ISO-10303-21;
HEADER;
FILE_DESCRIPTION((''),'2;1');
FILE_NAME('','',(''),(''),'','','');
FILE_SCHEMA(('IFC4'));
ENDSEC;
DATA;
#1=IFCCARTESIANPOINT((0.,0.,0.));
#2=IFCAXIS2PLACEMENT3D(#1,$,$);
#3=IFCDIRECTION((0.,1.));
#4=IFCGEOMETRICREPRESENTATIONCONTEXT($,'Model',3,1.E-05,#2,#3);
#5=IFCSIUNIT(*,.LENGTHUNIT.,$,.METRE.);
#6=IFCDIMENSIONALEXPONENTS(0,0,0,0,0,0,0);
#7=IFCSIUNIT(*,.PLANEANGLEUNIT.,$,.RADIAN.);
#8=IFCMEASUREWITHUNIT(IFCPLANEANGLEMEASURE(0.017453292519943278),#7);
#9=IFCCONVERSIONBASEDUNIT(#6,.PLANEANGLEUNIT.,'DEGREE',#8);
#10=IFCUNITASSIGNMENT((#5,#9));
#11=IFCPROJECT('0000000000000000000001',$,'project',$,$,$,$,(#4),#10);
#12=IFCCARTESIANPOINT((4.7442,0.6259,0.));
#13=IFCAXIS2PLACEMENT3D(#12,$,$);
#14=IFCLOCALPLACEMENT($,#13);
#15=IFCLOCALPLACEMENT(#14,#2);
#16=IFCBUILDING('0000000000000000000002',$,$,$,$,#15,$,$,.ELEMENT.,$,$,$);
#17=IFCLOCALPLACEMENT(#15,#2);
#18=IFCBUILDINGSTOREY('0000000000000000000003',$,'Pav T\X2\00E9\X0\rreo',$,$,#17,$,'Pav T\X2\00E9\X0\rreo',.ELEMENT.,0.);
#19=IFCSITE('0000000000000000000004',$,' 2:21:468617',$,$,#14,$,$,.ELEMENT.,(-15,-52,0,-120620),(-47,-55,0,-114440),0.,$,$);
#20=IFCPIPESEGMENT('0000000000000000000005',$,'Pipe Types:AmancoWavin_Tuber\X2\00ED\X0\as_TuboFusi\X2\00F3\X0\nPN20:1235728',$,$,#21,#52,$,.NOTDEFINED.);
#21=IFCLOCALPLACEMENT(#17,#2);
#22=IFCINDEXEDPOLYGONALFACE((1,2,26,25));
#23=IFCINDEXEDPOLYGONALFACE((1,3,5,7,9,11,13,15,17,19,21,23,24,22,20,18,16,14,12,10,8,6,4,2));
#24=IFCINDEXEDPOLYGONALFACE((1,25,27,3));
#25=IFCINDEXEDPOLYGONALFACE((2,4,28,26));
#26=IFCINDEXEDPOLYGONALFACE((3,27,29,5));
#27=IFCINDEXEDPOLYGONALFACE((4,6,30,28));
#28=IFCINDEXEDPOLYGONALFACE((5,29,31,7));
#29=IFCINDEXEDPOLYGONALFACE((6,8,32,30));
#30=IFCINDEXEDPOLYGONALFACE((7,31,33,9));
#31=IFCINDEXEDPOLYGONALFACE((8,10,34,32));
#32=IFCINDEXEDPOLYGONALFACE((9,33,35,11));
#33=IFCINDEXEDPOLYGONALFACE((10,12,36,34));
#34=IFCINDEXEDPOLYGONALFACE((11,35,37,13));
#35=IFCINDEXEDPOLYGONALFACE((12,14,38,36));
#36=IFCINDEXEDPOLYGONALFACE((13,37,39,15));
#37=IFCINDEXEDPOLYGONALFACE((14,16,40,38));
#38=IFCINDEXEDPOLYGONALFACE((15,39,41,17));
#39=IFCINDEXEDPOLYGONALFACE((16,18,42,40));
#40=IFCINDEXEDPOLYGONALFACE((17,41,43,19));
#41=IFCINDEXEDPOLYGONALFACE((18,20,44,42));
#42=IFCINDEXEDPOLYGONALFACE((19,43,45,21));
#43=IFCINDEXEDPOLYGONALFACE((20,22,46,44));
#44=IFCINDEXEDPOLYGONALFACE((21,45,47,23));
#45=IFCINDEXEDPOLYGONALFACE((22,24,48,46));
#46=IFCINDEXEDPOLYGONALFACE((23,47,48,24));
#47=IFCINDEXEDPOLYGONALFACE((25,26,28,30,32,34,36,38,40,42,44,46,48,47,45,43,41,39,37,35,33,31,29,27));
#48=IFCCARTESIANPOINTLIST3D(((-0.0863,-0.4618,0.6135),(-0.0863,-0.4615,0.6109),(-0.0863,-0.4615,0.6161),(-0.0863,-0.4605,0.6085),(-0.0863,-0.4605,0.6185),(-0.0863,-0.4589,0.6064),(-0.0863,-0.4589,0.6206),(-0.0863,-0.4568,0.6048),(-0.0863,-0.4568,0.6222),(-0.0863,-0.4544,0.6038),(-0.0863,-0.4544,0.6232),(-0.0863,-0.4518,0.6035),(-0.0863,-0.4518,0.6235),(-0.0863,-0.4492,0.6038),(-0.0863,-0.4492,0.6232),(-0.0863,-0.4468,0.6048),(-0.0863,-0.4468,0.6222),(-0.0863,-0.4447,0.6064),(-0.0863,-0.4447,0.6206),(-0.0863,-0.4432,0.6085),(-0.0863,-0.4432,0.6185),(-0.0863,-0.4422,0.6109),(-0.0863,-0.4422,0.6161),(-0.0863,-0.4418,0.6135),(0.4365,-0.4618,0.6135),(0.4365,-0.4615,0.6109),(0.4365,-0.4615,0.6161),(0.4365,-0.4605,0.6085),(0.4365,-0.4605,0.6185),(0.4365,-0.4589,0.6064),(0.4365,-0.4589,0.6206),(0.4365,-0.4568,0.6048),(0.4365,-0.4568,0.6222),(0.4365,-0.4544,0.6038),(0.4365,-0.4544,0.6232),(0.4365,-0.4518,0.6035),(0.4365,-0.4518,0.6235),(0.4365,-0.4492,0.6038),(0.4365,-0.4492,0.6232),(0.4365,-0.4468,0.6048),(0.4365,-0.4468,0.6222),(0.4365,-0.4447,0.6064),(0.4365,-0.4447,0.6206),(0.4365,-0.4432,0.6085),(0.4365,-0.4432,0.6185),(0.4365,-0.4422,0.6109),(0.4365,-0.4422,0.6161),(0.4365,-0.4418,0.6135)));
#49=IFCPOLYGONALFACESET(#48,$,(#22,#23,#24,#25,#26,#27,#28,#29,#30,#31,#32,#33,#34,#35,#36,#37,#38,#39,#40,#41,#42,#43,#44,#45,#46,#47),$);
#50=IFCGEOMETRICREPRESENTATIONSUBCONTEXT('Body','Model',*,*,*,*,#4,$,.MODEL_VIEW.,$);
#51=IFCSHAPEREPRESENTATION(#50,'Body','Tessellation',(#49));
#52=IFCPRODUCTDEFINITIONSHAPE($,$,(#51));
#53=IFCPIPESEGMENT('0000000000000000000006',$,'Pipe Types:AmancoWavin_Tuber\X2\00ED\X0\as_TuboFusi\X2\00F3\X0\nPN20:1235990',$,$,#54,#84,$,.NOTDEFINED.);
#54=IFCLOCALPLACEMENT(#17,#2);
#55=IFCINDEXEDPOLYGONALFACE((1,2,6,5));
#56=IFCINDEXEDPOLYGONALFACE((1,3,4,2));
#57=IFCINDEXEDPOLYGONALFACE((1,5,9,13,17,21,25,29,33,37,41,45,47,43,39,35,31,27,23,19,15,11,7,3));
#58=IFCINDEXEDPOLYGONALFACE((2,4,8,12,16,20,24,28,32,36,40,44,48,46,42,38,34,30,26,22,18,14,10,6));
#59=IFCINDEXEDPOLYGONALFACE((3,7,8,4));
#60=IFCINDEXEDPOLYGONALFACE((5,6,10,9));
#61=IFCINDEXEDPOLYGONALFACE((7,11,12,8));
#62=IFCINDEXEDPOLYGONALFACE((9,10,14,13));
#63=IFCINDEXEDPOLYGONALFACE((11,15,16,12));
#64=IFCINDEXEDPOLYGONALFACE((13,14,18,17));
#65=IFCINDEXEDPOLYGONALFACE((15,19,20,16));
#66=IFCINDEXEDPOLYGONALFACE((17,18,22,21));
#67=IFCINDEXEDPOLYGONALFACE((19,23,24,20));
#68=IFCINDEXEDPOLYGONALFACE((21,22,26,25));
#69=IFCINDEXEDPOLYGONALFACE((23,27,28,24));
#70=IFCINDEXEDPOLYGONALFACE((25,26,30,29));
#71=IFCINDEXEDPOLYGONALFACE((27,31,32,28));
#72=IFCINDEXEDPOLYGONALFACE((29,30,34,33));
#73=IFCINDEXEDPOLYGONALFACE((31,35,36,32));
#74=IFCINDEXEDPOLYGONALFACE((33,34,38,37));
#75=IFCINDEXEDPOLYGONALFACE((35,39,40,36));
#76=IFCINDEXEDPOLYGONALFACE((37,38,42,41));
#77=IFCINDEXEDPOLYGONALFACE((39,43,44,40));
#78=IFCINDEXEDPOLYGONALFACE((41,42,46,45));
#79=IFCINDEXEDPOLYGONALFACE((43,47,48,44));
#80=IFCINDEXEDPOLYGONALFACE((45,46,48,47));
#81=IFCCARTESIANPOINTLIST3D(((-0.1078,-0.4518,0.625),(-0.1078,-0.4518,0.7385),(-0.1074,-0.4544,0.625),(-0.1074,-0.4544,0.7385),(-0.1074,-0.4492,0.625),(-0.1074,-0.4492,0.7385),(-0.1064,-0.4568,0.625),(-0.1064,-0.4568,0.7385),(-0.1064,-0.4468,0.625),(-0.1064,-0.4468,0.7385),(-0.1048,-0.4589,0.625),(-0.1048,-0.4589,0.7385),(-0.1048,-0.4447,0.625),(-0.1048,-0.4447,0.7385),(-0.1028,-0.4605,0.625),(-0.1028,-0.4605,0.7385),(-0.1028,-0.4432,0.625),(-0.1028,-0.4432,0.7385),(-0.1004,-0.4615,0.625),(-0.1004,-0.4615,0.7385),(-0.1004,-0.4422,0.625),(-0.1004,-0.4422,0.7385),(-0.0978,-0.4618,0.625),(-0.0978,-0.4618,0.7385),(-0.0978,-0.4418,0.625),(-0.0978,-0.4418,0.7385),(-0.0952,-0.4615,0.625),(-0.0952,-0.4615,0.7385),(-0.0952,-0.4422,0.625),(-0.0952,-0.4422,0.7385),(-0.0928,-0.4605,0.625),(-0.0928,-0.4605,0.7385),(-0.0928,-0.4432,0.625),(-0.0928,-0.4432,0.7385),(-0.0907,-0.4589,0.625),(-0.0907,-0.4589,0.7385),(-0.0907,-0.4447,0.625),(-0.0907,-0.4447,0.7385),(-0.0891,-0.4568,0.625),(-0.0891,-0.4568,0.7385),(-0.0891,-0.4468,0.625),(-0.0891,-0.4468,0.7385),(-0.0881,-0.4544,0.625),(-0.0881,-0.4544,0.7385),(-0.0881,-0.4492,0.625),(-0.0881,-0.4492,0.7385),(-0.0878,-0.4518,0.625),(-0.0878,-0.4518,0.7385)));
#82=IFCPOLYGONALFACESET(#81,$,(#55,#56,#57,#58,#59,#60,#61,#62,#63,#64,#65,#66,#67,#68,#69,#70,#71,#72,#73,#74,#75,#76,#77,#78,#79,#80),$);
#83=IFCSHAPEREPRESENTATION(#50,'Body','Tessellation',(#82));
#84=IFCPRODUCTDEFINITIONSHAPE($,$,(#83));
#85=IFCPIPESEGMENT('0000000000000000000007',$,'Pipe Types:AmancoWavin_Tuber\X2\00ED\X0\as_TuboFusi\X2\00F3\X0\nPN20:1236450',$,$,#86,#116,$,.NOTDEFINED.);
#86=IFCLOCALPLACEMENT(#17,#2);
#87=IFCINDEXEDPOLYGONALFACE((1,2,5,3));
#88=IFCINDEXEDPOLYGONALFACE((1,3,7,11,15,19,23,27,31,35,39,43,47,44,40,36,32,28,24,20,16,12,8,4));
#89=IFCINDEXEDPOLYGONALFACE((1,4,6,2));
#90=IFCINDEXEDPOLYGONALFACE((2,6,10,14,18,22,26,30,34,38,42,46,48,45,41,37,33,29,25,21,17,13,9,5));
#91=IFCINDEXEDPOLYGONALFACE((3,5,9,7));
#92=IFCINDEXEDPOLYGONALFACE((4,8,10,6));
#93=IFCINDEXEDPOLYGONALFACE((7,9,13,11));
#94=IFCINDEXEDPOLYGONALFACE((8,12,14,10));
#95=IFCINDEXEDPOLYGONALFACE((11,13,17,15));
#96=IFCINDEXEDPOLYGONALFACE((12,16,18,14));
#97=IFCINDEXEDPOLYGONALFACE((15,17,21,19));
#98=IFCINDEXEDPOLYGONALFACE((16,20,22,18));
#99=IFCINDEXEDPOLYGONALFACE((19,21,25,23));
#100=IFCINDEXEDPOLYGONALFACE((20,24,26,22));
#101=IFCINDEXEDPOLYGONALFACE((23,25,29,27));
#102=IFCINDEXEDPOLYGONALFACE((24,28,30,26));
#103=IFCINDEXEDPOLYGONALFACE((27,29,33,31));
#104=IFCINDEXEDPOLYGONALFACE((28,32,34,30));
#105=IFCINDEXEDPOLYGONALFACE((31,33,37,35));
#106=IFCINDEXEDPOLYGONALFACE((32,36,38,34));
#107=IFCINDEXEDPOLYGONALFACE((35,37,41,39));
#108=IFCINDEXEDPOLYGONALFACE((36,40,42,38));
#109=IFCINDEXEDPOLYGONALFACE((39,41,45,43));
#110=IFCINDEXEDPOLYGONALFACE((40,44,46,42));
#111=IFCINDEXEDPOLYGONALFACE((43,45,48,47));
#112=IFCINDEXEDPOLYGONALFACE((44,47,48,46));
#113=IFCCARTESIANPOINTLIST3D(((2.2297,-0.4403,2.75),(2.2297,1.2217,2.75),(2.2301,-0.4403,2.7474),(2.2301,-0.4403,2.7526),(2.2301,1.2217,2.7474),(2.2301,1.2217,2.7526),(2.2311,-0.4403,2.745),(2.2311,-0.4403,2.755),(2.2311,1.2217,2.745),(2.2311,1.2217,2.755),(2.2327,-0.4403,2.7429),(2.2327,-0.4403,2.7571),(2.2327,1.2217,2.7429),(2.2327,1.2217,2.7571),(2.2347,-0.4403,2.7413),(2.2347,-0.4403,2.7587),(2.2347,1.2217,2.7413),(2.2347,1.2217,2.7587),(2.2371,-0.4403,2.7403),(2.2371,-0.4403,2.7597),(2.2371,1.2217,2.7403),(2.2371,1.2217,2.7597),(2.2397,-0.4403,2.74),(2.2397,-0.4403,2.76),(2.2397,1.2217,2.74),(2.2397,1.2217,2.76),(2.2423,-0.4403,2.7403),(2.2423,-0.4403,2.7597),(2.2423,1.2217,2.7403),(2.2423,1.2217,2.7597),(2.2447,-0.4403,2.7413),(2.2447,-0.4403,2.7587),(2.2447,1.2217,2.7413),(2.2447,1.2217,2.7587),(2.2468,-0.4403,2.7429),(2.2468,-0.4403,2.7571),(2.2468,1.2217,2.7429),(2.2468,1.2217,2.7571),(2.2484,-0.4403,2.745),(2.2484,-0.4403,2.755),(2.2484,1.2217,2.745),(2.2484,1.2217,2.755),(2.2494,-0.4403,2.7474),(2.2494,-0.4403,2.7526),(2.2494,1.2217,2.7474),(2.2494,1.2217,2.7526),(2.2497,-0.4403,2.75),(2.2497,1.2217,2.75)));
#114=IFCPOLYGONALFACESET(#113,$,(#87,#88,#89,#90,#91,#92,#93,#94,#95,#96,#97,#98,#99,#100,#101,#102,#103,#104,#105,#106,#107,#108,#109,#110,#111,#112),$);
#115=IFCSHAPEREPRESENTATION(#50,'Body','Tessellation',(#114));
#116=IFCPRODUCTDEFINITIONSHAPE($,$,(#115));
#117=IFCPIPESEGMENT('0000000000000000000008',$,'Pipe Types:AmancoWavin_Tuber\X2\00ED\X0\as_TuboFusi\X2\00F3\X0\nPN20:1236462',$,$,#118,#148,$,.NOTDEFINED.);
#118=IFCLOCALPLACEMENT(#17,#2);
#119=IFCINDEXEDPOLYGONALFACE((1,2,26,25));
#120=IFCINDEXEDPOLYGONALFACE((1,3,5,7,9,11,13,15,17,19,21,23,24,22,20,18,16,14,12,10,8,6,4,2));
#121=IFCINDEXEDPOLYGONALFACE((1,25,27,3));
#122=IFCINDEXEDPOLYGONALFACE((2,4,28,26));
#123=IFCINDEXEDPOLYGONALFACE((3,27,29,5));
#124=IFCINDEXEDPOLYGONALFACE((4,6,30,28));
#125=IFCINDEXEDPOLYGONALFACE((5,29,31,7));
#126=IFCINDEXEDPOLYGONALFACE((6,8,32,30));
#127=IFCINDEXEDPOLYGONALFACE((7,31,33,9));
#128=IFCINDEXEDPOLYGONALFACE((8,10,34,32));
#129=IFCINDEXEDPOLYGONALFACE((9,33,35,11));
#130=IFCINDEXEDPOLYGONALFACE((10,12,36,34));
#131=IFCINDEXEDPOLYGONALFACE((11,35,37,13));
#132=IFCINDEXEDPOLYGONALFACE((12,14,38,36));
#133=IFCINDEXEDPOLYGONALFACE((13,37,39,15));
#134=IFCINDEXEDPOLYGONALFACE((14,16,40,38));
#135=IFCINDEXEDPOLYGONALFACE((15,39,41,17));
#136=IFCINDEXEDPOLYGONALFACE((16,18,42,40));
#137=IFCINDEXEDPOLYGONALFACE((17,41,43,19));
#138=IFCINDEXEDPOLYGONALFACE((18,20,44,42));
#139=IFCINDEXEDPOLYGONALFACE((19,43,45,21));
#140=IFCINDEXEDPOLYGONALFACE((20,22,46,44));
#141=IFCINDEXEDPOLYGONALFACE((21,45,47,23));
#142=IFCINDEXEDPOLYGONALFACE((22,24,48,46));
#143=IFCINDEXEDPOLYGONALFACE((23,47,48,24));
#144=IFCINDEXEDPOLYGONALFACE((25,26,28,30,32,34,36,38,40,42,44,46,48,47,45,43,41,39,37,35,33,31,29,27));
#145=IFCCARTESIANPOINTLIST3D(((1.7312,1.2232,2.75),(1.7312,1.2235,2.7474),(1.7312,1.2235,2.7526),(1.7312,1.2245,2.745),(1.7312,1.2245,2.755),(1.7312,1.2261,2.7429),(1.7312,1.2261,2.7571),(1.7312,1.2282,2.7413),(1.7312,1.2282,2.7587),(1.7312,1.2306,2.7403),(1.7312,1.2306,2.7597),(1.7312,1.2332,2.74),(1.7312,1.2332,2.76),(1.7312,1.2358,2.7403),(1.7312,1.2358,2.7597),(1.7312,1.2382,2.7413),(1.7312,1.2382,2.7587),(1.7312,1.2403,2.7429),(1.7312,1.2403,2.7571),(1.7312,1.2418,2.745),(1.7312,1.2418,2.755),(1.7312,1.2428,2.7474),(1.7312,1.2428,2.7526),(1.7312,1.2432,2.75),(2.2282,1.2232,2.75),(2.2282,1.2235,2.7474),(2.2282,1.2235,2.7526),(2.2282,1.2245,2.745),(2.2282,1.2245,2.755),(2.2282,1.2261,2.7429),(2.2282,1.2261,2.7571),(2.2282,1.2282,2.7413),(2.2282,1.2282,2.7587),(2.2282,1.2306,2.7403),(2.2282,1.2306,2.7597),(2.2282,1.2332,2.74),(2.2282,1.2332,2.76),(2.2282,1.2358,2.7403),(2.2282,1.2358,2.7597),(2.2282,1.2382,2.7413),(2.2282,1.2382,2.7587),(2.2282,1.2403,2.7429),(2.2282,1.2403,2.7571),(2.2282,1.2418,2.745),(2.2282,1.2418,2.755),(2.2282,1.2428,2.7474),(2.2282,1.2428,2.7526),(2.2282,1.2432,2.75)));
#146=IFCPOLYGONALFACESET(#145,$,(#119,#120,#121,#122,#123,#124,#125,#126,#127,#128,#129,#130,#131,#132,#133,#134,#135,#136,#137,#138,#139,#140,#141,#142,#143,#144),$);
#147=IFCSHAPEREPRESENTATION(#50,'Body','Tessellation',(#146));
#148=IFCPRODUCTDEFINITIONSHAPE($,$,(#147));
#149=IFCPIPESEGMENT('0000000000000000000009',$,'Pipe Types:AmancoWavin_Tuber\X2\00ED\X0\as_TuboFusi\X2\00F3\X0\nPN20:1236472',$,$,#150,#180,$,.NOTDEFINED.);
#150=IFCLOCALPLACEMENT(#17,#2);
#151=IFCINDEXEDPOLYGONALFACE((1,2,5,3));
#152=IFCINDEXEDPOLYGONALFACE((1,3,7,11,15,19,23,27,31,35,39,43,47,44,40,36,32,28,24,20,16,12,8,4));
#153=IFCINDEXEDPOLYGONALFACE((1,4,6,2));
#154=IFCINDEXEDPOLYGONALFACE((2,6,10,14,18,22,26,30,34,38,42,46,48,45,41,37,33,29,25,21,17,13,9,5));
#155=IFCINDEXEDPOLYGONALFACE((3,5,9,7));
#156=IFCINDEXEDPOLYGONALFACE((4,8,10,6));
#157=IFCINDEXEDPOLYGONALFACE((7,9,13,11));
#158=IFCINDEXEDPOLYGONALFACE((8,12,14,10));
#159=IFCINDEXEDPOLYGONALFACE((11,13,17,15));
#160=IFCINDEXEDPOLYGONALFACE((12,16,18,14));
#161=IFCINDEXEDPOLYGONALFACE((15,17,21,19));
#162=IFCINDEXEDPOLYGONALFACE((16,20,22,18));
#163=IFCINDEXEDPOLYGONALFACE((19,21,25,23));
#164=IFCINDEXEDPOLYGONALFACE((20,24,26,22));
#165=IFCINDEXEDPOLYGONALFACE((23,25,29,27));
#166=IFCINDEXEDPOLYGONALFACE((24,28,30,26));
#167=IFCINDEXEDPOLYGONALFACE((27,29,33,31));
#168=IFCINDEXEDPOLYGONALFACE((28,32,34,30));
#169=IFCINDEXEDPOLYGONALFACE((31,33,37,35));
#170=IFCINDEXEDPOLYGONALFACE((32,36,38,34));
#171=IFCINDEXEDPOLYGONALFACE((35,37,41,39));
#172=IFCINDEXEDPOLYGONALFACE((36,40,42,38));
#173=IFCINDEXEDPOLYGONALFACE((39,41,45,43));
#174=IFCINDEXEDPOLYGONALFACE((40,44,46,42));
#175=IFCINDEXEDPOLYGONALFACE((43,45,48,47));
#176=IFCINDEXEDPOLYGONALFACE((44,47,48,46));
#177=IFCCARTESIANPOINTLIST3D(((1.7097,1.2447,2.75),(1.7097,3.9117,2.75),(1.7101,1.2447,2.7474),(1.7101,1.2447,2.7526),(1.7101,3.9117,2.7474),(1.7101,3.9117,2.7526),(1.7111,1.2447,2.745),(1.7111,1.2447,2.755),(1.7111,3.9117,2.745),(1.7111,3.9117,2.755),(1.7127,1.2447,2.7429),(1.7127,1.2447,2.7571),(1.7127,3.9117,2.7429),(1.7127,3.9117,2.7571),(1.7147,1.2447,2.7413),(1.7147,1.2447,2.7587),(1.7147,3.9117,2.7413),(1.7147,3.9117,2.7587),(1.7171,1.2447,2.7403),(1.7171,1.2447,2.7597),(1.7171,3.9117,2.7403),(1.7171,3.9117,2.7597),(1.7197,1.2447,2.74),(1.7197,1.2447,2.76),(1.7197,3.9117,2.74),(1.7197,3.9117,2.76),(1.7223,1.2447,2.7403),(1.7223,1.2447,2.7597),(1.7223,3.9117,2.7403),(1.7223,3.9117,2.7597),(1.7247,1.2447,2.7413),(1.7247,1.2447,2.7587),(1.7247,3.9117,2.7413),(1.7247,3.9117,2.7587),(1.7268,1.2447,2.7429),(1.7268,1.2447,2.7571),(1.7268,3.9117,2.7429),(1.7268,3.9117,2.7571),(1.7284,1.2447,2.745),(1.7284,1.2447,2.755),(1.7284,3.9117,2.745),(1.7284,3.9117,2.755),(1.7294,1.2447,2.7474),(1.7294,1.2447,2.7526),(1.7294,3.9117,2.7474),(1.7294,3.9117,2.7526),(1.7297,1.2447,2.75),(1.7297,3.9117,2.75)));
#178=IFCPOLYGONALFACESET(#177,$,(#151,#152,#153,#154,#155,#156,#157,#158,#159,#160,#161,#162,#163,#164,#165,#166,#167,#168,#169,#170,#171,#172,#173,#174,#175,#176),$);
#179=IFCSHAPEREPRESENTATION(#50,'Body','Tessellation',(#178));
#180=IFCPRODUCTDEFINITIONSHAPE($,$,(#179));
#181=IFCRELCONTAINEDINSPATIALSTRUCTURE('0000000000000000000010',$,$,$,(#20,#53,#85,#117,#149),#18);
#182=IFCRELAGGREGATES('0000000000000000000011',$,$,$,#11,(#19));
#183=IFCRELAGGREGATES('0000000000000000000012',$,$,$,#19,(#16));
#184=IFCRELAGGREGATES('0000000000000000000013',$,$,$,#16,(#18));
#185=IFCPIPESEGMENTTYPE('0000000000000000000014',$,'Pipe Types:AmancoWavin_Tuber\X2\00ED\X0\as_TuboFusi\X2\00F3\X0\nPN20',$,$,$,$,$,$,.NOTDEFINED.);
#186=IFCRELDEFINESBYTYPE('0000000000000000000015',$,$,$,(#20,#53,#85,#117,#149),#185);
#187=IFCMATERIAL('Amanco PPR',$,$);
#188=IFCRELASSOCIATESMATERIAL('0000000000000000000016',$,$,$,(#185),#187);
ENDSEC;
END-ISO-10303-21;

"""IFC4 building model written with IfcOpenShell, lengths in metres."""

from ifc_helpers import new_model, entity, si_unit, converted_unit, direction, frame, origin, place, context, subcontext, project, spatial, arc, indexed_curve, outline, extrude, material, type_object, element, save


model = new_model("IFC4")

# Units and contexts
model_context = context("Model", 3, precision=1e-05, world=origin(), true_north=direction((0.0, 1.0)))
body_context = subcontext(model_context, "Body", "Model", "MODEL_VIEW")
ifc_project = project(units=[si_unit("LENGTHUNIT", "METRE"), converted_unit("PLANEANGLEUNIT", "DEGREE", entity("IfcPlaneAngleMeasure", 0.017453292519943278), si_unit("PLANEANGLEUNIT", "RADIAN"), dimensions=[0, 0, 0, 0, 0, 0, 0])], contexts=[model_context])

# Site, building, storey
site_placement = place(None, frame((4.7442, 0.6259, 0.0)))
site = spatial("IfcSite", under=ifc_project, at=site_placement, Name=" 2:21:468617", CompositionType="ELEMENT", RefLatitude=(-15, -52, 0, -120620), RefLongitude=(-47, -55, 0, -114440), RefElevation=0.0)
building_placement = place(site_placement, origin())
building = spatial("IfcBuilding", under=site, at=building_placement, CompositionType="ELEMENT")
storey_placement = place(building_placement, origin())
storey = spatial("IfcBuildingStorey", under=building, at=storey_placement, Name="Pav Térreo", LongName="Pav Térreo", CompositionType="ELEMENT", Elevation=0.0)

# Pipe segments
ifc_material_1 = material(Name="Amanco PPR")
pipe_segment_type_1 = type_object("IfcPipeSegmentType", Name="Pipe Types:AmancoWavin_Tuberías_TuboFusiónPN20", PredefinedType="NOTDEFINED", material=ifc_material_1)
pipe_segment_1_placement = place(storey_placement, origin())
element("IfcPipeSegment", 1, at=pipe_segment_1_placement, inside=storey, type_object=pipe_segment_type_1, Name="Pipe Types:AmancoWavin_Tuberías_TuboFusiónPN20:1235728", PredefinedType="NOTDEFINED", context=body_context, shape_type="SweptSolid", body=[
    extrude(outline(indexed_curve([(0.01, 0.0), (0.0071, 0.0071), (0.0, 0.01), (-0.0071, 0.0071), (-0.01, 0.0), (-0.0071, -0.0071), (0.0, -0.01), (0.0071, -0.0071)], segments=[arc(1, 2, 3), arc(3, 4, 5), arc(5, 6, 7), arc(7, 8, 1)], self_intersect=False)), frame((-0.0863, -0.4518, 0.6135), z_axis=(1.0, 0.0, 0.0), x_axis=(0.0, 1.0, 0.0)), (0.0, 0.0, 1.0), 0.5228),
])
pipe_segment_2_placement = place(storey_placement, origin())
element("IfcPipeSegment", 2, at=pipe_segment_2_placement, inside=storey, type_object=pipe_segment_type_1, Name="Pipe Types:AmancoWavin_Tuberías_TuboFusiónPN20:1235990", PredefinedType="NOTDEFINED", context=body_context, shape_type="SweptSolid", body=[
    extrude(outline(indexed_curve([(0.01, 0.0), (0.0071, 0.0071), (0.0, 0.01), (-0.0071, 0.0071), (-0.01, 0.0), (-0.0071, -0.0071), (0.0, -0.01), (0.0071, -0.0071)], segments=[arc(1, 2, 3), arc(3, 4, 5), arc(5, 6, 7), arc(7, 8, 1)], self_intersect=False)), frame((-0.0978, -0.4518, 0.625), z_axis=(0.0, 0.0, 1.0), x_axis=(-1.0, 0.0, 0.0)), (0.0, 0.0, 1.0), 0.1135),
])
pipe_segment_3_placement = place(storey_placement, origin())
element("IfcPipeSegment", 3, at=pipe_segment_3_placement, inside=storey, type_object=pipe_segment_type_1, Name="Pipe Types:AmancoWavin_Tuberías_TuboFusiónPN20:1236450", PredefinedType="NOTDEFINED", context=body_context, shape_type="SweptSolid", body=[
    extrude(outline(indexed_curve([(0.01, 0.0), (0.0071, 0.0071), (0.0, 0.01), (-0.0071, 0.0071), (-0.01, 0.0), (-0.0071, -0.0071), (0.0, -0.01), (0.0071, -0.0071)], segments=[arc(1, 2, 3), arc(3, 4, 5), arc(5, 6, 7), arc(7, 8, 1)], self_intersect=False)), frame((2.2397, -0.4403, 2.75), z_axis=(0.0, 1.0, 0.0), x_axis=(1.0, 0.0, 0.0)), (0.0, 0.0, 1.0), 1.662),
])
pipe_segment_4_placement = place(storey_placement, origin())
element("IfcPipeSegment", 4, at=pipe_segment_4_placement, inside=storey, type_object=pipe_segment_type_1, Name="Pipe Types:AmancoWavin_Tuberías_TuboFusiónPN20:1236462", PredefinedType="NOTDEFINED", context=body_context, shape_type="SweptSolid", body=[
    extrude(outline(indexed_curve([(0.01, 0.0), (0.0071, 0.0071), (0.0, 0.01), (-0.0071, 0.0071), (-0.01, 0.0), (-0.0071, -0.0071), (0.0, -0.01), (0.0071, -0.0071)], segments=[arc(1, 2, 3), arc(3, 4, 5), arc(5, 6, 7), arc(7, 8, 1)], self_intersect=False)), frame((1.7312, 1.2332, 2.75), z_axis=(1.0, 0.0, 0.0), x_axis=(0.0, 1.0, 0.0)), (0.0, 0.0, 1.0), 0.497),
])
pipe_segment_5_placement = place(storey_placement, origin())
element("IfcPipeSegment", 5, at=pipe_segment_5_placement, inside=storey, type_object=pipe_segment_type_1, Name="Pipe Types:AmancoWavin_Tuberías_TuboFusiónPN20:1236472", PredefinedType="NOTDEFINED", context=body_context, shape_type="SweptSolid", body=[
    extrude(outline(indexed_curve([(0.01, 0.0), (0.0071, 0.0071), (0.0, 0.01), (-0.0071, 0.0071), (-0.01, 0.0), (-0.0071, -0.0071), (0.0, -0.01), (0.0071, -0.0071)], segments=[arc(1, 2, 3), arc(3, 4, 5), arc(5, 6, 7), arc(7, 8, 1)], self_intersect=False)), frame((1.7197, 1.2447, 2.75), z_axis=(0.0, 1.0, 0.0), x_axis=(1.0, 0.0, 0.0)), (0.0, 0.0, 1.0), 2.667),
])

save(model, "model.ifc")
